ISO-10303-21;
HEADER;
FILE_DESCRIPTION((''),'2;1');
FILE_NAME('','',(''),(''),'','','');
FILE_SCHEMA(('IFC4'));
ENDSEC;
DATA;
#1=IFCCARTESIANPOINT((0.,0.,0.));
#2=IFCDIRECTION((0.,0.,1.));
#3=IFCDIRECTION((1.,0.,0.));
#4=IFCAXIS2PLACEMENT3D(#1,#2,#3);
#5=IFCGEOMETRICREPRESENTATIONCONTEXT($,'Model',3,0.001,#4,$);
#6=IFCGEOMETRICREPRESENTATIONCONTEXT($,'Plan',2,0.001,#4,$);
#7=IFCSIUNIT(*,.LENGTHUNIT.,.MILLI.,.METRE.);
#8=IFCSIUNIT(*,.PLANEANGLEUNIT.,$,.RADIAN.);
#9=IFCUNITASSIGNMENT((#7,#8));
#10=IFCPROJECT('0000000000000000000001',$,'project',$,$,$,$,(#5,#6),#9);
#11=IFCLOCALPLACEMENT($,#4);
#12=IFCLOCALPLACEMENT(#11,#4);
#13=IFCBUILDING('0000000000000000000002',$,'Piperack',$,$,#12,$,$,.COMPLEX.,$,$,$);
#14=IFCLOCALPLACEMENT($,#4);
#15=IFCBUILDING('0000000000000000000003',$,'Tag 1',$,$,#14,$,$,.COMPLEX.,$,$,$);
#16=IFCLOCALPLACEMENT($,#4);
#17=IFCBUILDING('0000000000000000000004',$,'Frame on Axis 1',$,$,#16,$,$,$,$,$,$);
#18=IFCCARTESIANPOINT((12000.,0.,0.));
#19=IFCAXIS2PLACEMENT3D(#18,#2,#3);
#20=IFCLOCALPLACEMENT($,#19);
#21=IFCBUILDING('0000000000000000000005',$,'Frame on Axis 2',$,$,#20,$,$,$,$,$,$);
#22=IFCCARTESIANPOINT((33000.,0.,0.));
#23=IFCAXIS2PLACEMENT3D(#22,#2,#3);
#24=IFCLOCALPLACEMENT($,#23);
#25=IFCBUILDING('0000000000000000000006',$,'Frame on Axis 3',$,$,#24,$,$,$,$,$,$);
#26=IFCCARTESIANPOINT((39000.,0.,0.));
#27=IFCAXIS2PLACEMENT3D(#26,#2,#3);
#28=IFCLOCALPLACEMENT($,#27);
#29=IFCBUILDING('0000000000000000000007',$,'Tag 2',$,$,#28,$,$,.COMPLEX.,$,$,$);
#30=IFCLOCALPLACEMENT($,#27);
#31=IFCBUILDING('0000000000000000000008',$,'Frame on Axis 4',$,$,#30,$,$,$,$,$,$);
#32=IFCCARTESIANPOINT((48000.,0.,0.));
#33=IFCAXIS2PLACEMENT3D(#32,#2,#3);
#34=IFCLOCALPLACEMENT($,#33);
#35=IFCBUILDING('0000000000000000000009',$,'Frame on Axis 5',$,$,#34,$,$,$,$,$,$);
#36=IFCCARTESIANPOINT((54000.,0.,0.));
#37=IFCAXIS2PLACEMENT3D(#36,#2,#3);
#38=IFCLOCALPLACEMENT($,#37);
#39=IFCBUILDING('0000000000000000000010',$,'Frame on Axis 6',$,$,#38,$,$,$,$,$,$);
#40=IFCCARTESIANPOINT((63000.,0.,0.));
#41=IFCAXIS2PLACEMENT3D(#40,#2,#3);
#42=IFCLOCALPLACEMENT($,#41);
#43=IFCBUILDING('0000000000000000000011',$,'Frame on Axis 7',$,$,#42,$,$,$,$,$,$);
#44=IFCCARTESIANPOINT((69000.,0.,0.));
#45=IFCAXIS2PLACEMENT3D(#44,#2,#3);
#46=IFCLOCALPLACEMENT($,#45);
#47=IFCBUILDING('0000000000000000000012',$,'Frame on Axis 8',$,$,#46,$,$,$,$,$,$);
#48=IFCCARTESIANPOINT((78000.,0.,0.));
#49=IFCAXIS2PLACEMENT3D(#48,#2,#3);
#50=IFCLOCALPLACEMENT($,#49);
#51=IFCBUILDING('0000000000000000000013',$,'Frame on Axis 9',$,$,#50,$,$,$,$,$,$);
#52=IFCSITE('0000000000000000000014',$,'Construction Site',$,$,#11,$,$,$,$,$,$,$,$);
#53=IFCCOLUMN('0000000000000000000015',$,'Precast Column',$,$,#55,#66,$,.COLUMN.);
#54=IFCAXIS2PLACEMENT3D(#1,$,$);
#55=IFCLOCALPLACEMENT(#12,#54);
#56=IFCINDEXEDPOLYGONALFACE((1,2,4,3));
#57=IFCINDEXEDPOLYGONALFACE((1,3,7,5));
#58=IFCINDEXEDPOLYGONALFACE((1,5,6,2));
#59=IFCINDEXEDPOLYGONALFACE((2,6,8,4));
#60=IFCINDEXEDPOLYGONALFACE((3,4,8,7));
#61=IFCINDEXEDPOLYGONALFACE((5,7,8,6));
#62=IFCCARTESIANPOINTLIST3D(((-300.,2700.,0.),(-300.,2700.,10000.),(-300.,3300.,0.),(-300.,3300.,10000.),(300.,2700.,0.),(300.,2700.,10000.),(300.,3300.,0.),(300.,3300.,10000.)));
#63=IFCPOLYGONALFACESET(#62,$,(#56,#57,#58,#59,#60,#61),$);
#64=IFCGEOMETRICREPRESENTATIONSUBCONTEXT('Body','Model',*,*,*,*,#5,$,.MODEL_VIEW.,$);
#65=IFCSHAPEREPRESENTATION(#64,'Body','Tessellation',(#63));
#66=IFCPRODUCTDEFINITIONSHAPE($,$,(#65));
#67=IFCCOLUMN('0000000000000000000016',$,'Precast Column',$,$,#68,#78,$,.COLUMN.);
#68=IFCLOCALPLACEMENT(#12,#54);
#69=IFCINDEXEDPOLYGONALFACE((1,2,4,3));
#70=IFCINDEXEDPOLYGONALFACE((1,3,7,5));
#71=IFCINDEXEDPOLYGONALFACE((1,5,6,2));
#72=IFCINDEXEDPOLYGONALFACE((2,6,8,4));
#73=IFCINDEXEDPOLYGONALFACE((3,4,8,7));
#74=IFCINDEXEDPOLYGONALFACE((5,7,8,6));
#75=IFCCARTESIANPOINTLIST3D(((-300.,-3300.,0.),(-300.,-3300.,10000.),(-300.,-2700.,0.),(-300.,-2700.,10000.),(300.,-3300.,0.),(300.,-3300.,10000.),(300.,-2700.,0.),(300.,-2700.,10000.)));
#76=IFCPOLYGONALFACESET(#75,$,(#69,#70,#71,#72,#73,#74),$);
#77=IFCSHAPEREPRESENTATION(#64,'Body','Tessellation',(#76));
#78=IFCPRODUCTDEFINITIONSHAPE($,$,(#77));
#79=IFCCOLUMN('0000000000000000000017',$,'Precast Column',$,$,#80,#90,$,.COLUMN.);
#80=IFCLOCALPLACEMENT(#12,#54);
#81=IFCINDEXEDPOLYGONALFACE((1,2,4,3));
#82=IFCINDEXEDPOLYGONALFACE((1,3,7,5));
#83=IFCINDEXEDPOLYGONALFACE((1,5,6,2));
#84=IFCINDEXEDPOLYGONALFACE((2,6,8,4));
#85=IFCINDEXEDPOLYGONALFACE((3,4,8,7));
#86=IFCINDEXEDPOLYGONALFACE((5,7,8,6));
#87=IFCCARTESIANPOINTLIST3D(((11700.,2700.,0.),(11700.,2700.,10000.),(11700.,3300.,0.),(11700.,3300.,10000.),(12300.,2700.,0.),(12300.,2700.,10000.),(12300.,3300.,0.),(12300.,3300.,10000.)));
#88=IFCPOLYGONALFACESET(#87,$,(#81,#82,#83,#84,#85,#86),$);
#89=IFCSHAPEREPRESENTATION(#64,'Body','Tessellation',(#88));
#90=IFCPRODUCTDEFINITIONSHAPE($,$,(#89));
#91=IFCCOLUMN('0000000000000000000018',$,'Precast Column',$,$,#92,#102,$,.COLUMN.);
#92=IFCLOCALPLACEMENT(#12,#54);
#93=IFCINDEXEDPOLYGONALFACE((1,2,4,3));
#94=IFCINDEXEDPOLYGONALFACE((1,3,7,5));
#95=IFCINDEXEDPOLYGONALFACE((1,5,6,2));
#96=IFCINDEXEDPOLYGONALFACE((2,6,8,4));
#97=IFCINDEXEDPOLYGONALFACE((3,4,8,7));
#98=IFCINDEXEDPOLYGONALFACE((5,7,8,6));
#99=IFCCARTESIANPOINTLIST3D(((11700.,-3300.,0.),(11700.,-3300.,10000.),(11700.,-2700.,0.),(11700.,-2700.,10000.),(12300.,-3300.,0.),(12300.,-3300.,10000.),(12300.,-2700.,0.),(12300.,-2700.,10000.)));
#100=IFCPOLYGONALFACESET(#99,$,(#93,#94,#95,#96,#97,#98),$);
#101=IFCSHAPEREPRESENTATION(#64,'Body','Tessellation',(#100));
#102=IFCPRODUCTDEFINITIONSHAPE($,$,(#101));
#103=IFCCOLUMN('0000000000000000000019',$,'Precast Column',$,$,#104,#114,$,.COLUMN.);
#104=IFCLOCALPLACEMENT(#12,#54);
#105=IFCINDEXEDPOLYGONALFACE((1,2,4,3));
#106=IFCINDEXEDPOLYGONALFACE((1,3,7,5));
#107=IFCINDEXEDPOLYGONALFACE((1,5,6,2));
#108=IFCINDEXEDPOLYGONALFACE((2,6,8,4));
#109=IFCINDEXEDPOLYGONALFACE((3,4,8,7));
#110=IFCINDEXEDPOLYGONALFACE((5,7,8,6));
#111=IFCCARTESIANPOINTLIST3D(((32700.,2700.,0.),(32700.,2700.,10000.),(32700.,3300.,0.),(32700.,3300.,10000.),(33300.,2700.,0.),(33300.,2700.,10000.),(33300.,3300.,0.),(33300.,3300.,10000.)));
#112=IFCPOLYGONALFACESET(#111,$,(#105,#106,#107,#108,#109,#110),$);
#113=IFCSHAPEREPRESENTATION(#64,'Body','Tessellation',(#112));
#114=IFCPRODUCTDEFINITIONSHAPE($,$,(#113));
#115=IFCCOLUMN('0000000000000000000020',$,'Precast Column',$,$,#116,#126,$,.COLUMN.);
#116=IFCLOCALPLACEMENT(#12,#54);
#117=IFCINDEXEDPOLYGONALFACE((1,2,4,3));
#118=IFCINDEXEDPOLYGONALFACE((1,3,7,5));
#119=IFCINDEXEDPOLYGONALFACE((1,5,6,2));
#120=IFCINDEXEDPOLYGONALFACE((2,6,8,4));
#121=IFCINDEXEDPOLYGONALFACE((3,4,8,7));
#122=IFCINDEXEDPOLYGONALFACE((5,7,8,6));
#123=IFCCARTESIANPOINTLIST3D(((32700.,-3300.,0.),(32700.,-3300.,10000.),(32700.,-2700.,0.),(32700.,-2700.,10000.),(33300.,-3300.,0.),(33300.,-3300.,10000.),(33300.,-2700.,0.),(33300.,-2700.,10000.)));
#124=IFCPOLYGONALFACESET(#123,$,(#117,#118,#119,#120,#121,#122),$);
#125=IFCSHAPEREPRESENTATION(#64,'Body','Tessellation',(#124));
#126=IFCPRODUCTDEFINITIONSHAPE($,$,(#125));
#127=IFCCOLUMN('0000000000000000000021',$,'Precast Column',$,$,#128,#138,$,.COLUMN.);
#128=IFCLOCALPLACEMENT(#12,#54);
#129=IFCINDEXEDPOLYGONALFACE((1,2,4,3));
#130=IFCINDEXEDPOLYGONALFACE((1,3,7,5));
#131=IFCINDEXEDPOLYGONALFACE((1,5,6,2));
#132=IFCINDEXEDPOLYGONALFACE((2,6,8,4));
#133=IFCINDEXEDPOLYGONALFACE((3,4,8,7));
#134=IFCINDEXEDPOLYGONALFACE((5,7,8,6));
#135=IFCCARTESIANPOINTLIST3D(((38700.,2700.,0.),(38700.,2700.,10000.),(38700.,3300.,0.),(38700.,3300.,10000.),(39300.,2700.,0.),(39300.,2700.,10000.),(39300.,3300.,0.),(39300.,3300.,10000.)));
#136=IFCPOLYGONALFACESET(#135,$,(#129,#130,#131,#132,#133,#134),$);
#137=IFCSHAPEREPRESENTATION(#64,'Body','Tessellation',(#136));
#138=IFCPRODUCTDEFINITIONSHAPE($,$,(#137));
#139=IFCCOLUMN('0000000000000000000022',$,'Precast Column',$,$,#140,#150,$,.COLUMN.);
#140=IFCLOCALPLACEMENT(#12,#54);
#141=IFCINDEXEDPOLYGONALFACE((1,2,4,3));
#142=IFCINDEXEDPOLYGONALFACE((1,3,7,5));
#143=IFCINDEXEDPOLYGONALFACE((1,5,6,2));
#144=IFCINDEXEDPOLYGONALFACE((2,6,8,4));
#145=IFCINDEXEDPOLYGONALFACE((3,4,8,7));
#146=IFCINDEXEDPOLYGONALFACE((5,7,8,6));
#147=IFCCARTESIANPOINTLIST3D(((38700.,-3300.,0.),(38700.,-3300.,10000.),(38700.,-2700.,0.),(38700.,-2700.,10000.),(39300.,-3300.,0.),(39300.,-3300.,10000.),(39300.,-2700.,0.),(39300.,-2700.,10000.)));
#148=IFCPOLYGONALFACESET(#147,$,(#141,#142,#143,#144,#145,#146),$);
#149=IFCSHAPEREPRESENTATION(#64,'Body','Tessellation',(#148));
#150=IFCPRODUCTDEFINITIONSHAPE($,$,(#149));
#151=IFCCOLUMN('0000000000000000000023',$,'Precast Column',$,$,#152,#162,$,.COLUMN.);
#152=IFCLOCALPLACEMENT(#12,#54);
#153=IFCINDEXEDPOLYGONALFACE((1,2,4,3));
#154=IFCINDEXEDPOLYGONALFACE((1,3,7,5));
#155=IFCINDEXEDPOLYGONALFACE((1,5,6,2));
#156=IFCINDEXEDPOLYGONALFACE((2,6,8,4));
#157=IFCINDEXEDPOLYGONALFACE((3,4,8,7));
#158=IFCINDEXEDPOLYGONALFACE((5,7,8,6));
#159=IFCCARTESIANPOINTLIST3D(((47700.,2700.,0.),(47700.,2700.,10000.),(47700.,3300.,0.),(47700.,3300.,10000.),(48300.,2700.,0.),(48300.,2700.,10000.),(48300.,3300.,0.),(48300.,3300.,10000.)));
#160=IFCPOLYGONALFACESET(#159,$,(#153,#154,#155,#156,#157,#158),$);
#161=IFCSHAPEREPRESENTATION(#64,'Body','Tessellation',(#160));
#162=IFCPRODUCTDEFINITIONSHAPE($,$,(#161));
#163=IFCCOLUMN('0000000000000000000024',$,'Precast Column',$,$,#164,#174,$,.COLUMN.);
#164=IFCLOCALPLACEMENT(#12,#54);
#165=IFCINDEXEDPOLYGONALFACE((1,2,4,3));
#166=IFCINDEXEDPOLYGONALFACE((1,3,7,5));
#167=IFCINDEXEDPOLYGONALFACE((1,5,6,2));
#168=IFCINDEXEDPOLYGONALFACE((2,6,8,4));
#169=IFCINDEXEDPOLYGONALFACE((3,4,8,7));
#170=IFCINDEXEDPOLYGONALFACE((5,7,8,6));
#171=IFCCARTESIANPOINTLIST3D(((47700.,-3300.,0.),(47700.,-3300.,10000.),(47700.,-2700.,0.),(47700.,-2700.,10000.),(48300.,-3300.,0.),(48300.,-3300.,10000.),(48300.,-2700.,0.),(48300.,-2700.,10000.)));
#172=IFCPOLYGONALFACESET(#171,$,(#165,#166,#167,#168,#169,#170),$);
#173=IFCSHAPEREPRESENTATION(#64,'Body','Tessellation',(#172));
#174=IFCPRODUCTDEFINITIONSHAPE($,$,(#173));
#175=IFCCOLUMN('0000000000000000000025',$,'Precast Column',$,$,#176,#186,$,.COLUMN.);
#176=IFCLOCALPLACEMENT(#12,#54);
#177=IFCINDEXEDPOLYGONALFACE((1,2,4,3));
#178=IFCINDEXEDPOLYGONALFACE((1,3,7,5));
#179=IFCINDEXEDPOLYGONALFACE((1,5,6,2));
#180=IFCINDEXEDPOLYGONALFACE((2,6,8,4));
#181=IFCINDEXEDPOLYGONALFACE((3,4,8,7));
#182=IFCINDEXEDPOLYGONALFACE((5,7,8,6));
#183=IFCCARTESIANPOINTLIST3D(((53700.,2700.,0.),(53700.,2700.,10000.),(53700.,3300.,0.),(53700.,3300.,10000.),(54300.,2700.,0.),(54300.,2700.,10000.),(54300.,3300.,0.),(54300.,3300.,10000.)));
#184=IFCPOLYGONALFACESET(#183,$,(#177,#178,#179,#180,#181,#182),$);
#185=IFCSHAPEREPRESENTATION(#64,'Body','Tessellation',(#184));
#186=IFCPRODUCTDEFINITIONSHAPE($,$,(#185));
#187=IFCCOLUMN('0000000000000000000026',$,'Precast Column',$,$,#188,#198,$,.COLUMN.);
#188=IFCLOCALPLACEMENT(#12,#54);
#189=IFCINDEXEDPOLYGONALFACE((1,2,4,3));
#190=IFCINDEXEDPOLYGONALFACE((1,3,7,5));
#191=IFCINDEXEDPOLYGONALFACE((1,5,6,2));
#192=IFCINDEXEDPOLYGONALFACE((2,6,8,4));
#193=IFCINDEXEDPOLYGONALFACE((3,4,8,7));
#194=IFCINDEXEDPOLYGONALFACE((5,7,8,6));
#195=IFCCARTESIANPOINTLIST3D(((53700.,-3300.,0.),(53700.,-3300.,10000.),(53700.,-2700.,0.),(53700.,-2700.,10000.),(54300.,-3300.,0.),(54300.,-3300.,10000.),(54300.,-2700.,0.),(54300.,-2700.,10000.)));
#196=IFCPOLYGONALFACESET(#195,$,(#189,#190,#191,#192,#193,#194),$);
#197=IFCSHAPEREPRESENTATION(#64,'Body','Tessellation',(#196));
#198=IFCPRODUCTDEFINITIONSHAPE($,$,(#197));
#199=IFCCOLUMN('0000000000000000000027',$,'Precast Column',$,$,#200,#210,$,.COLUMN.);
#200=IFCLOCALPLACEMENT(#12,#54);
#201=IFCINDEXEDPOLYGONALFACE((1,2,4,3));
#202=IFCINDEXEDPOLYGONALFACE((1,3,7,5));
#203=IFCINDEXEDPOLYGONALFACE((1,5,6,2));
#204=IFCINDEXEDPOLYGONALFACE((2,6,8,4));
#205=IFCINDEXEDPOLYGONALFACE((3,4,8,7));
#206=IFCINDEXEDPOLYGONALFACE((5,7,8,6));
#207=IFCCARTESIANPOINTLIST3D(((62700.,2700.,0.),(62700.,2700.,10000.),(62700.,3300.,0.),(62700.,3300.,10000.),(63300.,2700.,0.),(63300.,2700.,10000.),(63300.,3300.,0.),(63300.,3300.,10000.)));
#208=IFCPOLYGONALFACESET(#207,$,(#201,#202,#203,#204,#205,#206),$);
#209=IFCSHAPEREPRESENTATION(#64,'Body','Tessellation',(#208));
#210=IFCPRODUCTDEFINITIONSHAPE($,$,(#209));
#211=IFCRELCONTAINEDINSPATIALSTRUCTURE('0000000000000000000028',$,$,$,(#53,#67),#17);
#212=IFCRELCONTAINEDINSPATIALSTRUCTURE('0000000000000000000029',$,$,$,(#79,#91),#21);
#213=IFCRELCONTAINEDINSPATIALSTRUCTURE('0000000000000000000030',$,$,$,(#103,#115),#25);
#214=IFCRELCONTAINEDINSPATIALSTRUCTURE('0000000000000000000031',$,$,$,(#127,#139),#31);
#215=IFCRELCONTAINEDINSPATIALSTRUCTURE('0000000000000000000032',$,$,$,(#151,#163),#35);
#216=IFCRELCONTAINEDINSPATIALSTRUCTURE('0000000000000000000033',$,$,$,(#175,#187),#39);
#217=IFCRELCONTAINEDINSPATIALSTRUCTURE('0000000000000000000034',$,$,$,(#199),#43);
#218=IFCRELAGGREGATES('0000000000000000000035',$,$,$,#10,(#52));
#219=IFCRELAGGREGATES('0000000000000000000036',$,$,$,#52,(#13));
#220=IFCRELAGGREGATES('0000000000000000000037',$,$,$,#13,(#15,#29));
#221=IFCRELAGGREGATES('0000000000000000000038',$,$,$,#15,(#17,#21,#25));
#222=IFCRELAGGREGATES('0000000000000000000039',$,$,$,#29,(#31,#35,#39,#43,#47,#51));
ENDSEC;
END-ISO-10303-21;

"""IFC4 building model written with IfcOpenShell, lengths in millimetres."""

from ifc_helpers import new_model, si_unit, frame, origin, origin_with_axes, place, context, subcontext, project, spatial, rectangle, extrude, element, save


model = new_model("IFC4")

# Units and contexts
model_context = context("Model", 3, precision=0.001, world=origin_with_axes())
plan_context = context("Plan", 2, precision=0.001, world=origin_with_axes())
body_context = subcontext(model_context, "Body", "Model", "MODEL_VIEW")
ifc_project = project(units=[si_unit("LENGTHUNIT", "METRE", prefix="MILLI"), si_unit("PLANEANGLEUNIT", "RADIAN")], contexts=[model_context, plan_context])

# Site, buildings
site_placement = place(None, origin_with_axes())
site = spatial("IfcSite", under=ifc_project, at=site_placement, Name="Construction Site")
building_1_placement = place(site_placement, origin_with_axes())
building_1 = spatial("IfcBuilding", under=site, at=building_1_placement, Name="Piperack", CompositionType="COMPLEX")
building_2_placement = place(None, origin_with_axes())
building_2 = spatial("IfcBuilding", under=building_1, at=building_2_placement, Name="Tag 1", CompositionType="COMPLEX")
building_3_placement = place(None, origin_with_axes())
building_3 = spatial("IfcBuilding", under=building_2, at=building_3_placement, Name="Frame on Axis 1")

# Columns
for number, where, z_axis, name in (
    (1, (0.0, 3000.0, 0.0), (0.0, 0.0, 1.0), "Precast Column"),
    (2, (0.0, -3000.0, 0.0), (0.0, 0.0, 1.0), "Precast Column"),
):
    element("IfcColumn", number, at=place(building_3_placement, frame(where, z_axis=z_axis)), inside=building_3, Name=name, PredefinedType="COLUMN", context=body_context, shape_type="SweptSolid", body=[
        extrude(rectangle(XDim=600.0, YDim=600.0), origin(), (0.0, 0.0, 1.0), 10000.0),
    ])

# Shared definitions
building_4_placement = place(None, frame((12000.0, 0.0, 0.0), z_axis=(0.0, 0.0, 1.0), x_axis=(1.0, 0.0, 0.0)))
building_4 = spatial("IfcBuilding", under=building_2, at=building_4_placement, Name="Frame on Axis 2")

# Columns
for number, where, z_axis, name in (
    (3, (0.0, 3000.0, 0.0), (0.0, 0.0, 1.0), "Precast Column"),
    (4, (0.0, -3000.0, 0.0), (0.0, 0.0, 1.0), "Precast Column"),
):
    element("IfcColumn", number, at=place(building_4_placement, frame(where, z_axis=z_axis)), inside=building_4, Name=name, PredefinedType="COLUMN", context=body_context, shape_type="SweptSolid", body=[
        extrude(rectangle(XDim=600.0, YDim=600.0), origin(), (0.0, 0.0, 1.0), 10000.0),
    ])

# Shared definitions
building_5_placement = place(None, frame((33000.0, 0.0, 0.0), z_axis=(0.0, 0.0, 1.0), x_axis=(1.0, 0.0, 0.0)))
building_5 = spatial("IfcBuilding", under=building_2, at=building_5_placement, Name="Frame on Axis 3")

# Columns
for number, where, z_axis, name in (
    (5, (0.0, 3000.0, 0.0), (0.0, 0.0, 1.0), "Precast Column"),
    (6, (0.0, -3000.0, 0.0), (0.0, 0.0, 1.0), "Precast Column"),
):
    element("IfcColumn", number, at=place(building_5_placement, frame(where, z_axis=z_axis)), inside=building_5, Name=name, PredefinedType="COLUMN", context=body_context, shape_type="SweptSolid", body=[
        extrude(rectangle(XDim=600.0, YDim=600.0), origin(), (0.0, 0.0, 1.0), 10000.0),
    ])

# Shared definitions
building_6_placement = place(None, frame((39000.0, 0.0, 0.0), z_axis=(0.0, 0.0, 1.0), x_axis=(1.0, 0.0, 0.0)))
building_6 = spatial("IfcBuilding", under=building_1, at=building_6_placement, Name="Tag 2", CompositionType="COMPLEX")
building_7_placement = place(None, frame((39000.0, 0.0, 0.0), z_axis=(0.0, 0.0, 1.0), x_axis=(1.0, 0.0, 0.0)))
building_7 = spatial("IfcBuilding", under=building_6, at=building_7_placement, Name="Frame on Axis 4")

# Columns
for number, where, z_axis, name in (
    (7, (0.0, 3000.0, 0.0), (0.0, 0.0, 1.0), "Precast Column"),
    (8, (0.0, -3000.0, 0.0), (0.0, 0.0, 1.0), "Precast Column"),
):
    element("IfcColumn", number, at=place(building_7_placement, frame(where, z_axis=z_axis)), inside=building_7, Name=name, PredefinedType="COLUMN", context=body_context, shape_type="SweptSolid", body=[
        extrude(rectangle(XDim=600.0, YDim=600.0), origin(), (0.0, 0.0, 1.0), 10000.0),
    ])

# Shared definitions
building_8_placement = place(None, frame((48000.0, 0.0, 0.0), z_axis=(0.0, 0.0, 1.0), x_axis=(1.0, 0.0, 0.0)))
building_8 = spatial("IfcBuilding", under=building_6, at=building_8_placement, Name="Frame on Axis 5")

# Columns
for number, where, z_axis, name in (
    (9, (0.0, 3000.0, 0.0), (0.0, 0.0, 1.0), "Precast Column"),
    (10, (0.0, -3000.0, 0.0), (0.0, 0.0, 1.0), "Precast Column"),
):
    element("IfcColumn", number, at=place(building_8_placement, frame(where, z_axis=z_axis)), inside=building_8, Name=name, PredefinedType="COLUMN", context=body_context, shape_type="SweptSolid", body=[
        extrude(rectangle(XDim=600.0, YDim=600.0), origin(), (0.0, 0.0, 1.0), 10000.0),
    ])

# Shared definitions
building_9_placement = place(None, frame((54000.0, 0.0, 0.0), z_axis=(0.0, 0.0, 1.0), x_axis=(1.0, 0.0, 0.0)))
building_9 = spatial("IfcBuilding", under=building_6, at=building_9_placement, Name="Frame on Axis 6")

# Columns
for number, where, z_axis, name in (
    (11, (0.0, 3000.0, 0.0), (0.0, 0.0, 1.0), "Precast Column"),
    (12, (0.0, -3000.0, 0.0), (0.0, 0.0, 1.0), "Precast Column"),
):
    element("IfcColumn", number, at=place(building_9_placement, frame(where, z_axis=z_axis)), inside=building_9, Name=name, PredefinedType="COLUMN", context=body_context, shape_type="SweptSolid", body=[
        extrude(rectangle(XDim=600.0, YDim=600.0), origin(), (0.0, 0.0, 1.0), 10000.0),
    ])

# Shared definitions
building_10_placement = place(None, frame((63000.0, 0.0, 0.0), z_axis=(0.0, 0.0, 1.0), x_axis=(1.0, 0.0, 0.0)))
building_10 = spatial("IfcBuilding", under=building_6, at=building_10_placement, Name="Frame on Axis 7")

# Column
for number, where, z_axis, name in (
    (13, (0.0, 3000.0, 0.0), (0.0, 0.0, 1.0), "Precast Column"),
):
    element("IfcColumn", number, at=place(building_10_placement, frame(where, z_axis=z_axis)), inside=building_10, Name=name, PredefinedType="COLUMN", context=body_context, shape_type="SweptSolid", body=[
        extrude(rectangle(XDim=600.0, YDim=600.0), origin(), (0.0, 0.0, 1.0), 10000.0),
    ])

# Shared definitions
building_11_placement = place(None, frame((69000.0, 0.0, 0.0), z_axis=(0.0, 0.0, 1.0), x_axis=(1.0, 0.0, 0.0)))
building_11 = spatial("IfcBuilding", under=building_6, at=building_11_placement, Name="Frame on Axis 8")

# Shared definitions
building_12_placement = place(None, frame((78000.0, 0.0, 0.0), z_axis=(0.0, 0.0, 1.0), x_axis=(1.0, 0.0, 0.0)))
building_12 = spatial("IfcBuilding", under=building_6, at=building_12_placement, Name="Frame on Axis 9")

save(model, "model.ifc")
